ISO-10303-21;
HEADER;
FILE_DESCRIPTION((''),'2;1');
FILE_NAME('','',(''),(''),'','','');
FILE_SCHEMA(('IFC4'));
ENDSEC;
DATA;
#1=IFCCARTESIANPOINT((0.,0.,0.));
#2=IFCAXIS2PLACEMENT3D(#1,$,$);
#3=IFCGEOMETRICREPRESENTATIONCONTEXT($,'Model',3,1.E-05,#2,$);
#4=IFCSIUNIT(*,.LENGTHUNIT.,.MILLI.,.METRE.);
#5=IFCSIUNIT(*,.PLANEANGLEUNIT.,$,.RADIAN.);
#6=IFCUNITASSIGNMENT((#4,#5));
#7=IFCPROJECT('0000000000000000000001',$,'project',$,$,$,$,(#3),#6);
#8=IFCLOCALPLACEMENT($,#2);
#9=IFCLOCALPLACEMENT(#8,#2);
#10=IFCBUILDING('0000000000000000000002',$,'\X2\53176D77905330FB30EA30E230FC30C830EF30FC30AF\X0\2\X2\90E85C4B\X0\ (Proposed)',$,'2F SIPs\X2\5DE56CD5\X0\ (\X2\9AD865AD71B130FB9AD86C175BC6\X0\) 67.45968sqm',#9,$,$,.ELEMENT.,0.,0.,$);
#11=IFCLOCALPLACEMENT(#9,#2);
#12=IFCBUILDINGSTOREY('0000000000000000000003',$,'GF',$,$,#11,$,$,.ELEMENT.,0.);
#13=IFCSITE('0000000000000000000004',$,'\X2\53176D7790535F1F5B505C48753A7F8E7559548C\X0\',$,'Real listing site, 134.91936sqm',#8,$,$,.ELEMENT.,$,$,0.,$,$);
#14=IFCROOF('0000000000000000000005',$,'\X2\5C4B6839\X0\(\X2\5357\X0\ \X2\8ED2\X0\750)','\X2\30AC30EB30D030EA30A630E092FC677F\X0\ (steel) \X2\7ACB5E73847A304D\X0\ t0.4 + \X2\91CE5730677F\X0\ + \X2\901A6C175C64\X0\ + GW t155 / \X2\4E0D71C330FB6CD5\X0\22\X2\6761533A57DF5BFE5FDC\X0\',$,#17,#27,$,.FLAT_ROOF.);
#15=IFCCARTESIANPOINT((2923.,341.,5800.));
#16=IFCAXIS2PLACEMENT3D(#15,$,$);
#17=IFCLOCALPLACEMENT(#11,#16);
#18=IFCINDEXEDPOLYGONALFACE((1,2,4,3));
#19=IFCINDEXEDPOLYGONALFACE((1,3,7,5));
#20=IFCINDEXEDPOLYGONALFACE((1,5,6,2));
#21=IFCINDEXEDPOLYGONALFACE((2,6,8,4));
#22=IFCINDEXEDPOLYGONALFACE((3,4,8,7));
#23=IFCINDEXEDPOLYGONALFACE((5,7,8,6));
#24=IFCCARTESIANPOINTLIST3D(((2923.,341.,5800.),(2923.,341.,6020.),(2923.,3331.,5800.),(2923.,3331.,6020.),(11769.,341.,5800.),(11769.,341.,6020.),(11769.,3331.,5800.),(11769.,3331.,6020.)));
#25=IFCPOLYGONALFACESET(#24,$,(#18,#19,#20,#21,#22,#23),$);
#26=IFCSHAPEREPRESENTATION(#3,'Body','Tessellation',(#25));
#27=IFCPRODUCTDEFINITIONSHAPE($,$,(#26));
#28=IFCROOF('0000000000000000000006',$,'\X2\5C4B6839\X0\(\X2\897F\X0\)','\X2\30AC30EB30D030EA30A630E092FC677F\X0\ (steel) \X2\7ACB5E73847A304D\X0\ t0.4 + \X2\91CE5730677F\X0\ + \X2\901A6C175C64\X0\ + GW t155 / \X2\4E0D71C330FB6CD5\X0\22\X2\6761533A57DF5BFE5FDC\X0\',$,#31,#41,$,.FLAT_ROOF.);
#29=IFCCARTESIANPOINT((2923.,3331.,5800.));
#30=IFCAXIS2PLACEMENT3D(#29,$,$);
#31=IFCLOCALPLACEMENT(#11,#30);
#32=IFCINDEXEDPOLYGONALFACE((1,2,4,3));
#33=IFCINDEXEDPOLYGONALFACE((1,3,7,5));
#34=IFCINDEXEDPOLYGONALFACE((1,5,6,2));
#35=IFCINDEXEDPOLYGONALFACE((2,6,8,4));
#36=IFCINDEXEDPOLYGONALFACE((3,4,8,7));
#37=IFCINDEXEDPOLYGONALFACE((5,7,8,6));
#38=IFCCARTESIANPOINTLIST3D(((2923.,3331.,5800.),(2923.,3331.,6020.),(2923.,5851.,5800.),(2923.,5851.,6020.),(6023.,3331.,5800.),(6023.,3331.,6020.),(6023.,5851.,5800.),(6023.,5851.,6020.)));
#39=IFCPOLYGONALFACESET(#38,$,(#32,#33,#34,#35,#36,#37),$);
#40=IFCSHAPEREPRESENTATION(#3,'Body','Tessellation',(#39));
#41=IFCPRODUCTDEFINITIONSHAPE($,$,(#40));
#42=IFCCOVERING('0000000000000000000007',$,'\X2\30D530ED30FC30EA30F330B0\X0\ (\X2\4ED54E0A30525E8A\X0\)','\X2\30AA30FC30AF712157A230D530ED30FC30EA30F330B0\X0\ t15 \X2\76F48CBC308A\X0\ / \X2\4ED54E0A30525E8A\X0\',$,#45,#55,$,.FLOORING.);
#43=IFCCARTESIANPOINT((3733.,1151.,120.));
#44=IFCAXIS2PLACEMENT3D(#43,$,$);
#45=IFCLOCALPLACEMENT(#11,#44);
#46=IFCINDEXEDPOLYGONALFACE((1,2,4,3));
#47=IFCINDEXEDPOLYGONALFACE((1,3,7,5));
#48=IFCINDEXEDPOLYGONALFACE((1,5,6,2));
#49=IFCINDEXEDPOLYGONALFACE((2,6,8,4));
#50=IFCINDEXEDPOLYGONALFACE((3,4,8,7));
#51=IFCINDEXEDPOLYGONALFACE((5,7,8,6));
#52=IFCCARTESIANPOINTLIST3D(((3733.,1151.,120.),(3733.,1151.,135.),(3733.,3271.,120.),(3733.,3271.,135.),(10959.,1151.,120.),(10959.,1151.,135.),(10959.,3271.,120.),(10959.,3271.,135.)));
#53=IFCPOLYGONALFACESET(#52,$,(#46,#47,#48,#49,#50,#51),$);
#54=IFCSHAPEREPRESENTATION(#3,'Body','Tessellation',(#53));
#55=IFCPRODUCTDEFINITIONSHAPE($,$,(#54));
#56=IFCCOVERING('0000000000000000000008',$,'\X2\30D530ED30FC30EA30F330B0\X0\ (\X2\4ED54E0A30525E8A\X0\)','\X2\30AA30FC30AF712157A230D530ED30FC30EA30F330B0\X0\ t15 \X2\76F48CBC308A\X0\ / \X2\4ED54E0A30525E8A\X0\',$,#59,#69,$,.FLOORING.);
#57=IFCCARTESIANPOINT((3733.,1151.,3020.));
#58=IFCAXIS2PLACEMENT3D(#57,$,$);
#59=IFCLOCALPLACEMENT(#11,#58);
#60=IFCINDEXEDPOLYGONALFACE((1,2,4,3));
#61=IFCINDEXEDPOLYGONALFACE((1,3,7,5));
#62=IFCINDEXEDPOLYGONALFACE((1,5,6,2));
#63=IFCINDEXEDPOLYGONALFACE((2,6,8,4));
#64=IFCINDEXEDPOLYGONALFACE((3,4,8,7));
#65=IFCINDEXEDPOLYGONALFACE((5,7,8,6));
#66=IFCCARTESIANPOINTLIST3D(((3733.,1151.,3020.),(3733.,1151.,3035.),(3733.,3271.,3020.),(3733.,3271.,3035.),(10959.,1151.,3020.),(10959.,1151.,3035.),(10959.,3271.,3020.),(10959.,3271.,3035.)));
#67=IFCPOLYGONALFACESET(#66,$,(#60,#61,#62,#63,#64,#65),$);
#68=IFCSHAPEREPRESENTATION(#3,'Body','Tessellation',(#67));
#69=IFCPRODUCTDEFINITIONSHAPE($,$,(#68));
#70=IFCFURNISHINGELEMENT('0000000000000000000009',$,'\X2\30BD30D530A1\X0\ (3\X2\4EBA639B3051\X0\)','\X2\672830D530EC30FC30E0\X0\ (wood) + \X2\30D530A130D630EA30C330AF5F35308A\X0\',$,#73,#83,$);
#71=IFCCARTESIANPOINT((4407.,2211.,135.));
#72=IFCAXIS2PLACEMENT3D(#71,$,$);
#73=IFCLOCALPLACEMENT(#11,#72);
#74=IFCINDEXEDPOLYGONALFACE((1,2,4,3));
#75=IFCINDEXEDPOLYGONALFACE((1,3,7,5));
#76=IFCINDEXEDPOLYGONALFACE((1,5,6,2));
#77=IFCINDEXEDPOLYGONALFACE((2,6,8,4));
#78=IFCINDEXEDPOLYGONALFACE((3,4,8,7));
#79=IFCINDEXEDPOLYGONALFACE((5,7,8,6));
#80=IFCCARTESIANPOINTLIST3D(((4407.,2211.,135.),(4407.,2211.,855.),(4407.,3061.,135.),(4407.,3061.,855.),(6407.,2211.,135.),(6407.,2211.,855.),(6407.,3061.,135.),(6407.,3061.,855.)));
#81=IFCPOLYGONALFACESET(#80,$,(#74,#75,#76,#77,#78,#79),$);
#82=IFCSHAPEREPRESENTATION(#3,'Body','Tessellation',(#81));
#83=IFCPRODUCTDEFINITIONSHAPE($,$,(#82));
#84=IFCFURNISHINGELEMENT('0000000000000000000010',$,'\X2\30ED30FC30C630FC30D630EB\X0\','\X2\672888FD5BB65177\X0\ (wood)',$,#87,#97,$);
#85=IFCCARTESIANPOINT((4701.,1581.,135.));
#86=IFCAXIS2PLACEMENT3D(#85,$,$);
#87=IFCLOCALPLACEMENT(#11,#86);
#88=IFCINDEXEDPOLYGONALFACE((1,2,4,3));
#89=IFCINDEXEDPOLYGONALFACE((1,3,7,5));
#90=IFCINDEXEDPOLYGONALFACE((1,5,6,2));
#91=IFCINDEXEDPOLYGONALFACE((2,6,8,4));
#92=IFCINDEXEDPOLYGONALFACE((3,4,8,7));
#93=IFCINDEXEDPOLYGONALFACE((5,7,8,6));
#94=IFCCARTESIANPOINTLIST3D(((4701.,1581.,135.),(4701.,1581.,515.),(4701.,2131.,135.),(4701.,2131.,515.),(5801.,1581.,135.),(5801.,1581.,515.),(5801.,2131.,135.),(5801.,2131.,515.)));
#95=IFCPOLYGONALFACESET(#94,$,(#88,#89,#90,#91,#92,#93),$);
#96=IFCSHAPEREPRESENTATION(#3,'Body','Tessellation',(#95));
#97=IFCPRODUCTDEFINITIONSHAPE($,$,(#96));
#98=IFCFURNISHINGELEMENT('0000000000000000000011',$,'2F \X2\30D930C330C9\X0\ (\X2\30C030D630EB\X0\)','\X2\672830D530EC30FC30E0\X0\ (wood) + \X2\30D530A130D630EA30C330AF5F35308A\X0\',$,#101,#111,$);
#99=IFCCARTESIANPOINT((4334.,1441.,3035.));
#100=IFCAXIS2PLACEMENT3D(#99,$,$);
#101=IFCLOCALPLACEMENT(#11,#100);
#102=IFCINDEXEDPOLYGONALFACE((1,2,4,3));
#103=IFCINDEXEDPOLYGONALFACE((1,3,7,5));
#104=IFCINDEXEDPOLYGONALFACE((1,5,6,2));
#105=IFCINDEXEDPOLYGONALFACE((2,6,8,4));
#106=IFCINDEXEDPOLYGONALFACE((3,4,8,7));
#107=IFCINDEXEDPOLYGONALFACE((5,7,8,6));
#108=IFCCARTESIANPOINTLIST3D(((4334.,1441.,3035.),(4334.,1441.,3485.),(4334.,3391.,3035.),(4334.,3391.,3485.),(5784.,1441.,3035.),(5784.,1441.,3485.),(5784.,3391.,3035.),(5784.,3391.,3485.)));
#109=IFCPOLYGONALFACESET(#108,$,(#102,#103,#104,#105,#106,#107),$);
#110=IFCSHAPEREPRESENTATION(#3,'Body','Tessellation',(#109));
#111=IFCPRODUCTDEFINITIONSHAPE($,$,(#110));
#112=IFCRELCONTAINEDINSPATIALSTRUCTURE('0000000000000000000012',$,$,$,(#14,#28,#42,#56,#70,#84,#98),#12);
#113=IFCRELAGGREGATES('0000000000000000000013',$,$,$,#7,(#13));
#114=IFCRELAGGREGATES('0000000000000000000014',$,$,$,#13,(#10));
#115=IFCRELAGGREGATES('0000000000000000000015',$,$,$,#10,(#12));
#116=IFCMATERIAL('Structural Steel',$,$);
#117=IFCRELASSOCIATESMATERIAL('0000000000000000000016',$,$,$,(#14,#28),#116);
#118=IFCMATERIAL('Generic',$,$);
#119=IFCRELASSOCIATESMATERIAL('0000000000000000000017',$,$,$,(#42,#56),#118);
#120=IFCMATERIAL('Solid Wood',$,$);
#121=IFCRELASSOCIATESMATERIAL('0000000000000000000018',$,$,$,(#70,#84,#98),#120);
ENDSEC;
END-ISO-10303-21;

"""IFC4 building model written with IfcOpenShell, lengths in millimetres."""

from ifc_helpers import new_model, si_unit, frame, frame_2d, origin, place, context, project, spatial, rectangle, extrude, material, element, save


model = new_model("IFC4")

# Units and contexts
model_context = context("Model", 3, precision=1e-05, world=origin())
ifc_project = project(units=[si_unit("LENGTHUNIT", "METRE", prefix="MILLI"), si_unit("PLANEANGLEUNIT", "RADIAN")], contexts=[model_context])

# Site, building, storey
site_placement = place(None, origin())
site = spatial("IfcSite", under=ifc_project, at=site_placement, Name="北海道弟子屈町美留和", ObjectType="Real listing site, 134.91936sqm", CompositionType="ELEMENT", RefElevation=0.0)
building_placement = place(site_placement, origin())
building = spatial("IfcBuilding", under=site, at=building_placement, Name="北海道・リモートワーク2部屋 (Proposed)", ObjectType="2F SIPs工法 (高断熱・高気密) 67.45968sqm", CompositionType="ELEMENT", ElevationOfRefHeight=0.0, ElevationOfTerrain=0.0)
storey_placement = place(building_placement, origin())
storey = spatial("IfcBuildingStorey", under=building, at=storey_placement, Name="GF", CompositionType="ELEMENT", Elevation=0.0)

# Shared definitions
ifc_material_1 = material(Name="Solid Wood")

# Roofs
ifc_material_2 = material(Name="Structural Steel")
roof_1_placement = place(storey_placement, frame((2923.0, 341.0, 5800.0)))
element("IfcRoof", 1, at=roof_1_placement, inside=storey, material=ifc_material_2, Name="屋根(南 軒750)", Description="ガルバリウム鋼板 (steel) 立平葺き t0.4 + 野地板 + 通気層 + GW t155 / 不燃・法22条区域対応", PredefinedType="FLAT_ROOF", context=model_context, shape_type="SweptSolid", body=[
    extrude(rectangle(XDim=8846.0, YDim=2990.0, at=frame_2d((4423.0, 1495.0))), frame((2923.0, 341.0, 5800.0)), (0.0, 0.0, 1.0), 220.0),
])
roof_2_placement = place(storey_placement, frame((2923.0, 3331.0, 5800.0)))
element("IfcRoof", 2, at=roof_2_placement, inside=storey, material=ifc_material_2, Name="屋根(西)", Description="ガルバリウム鋼板 (steel) 立平葺き t0.4 + 野地板 + 通気層 + GW t155 / 不燃・法22条区域対応", PredefinedType="FLAT_ROOF", context=model_context, shape_type="SweptSolid", body=[
    extrude(rectangle(XDim=3100.0, YDim=2520.0, at=frame_2d((1550.0, 1260.0))), frame((2923.0, 3331.0, 5800.0)), (0.0, 0.0, 1.0), 220.0),
])

# Coverings
ifc_material_3 = material(Name="Generic")
covering_1_placement = place(storey_placement, frame((3733.0, 1151.0, 120.0)))
element("IfcCovering", 3, at=covering_1_placement, inside=storey, material=ifc_material_3, Name="フローリング (仕上げ床)", Description="オーク無垢フローリング t15 直貼り / 仕上げ床", PredefinedType="FLOORING", context=model_context, shape_type="SweptSolid", body=[
    extrude(rectangle(XDim=7226.0, YDim=2120.0, at=frame_2d((3613.0, 1060.0))), frame((3733.0, 1151.0, 120.0)), (0.0, 0.0, 1.0), 15.0),
])
covering_2_placement = place(storey_placement, frame((3733.0, 1151.0, 3020.0)))
element("IfcCovering", 4, at=covering_2_placement, inside=storey, material=ifc_material_3, Name="フローリング (仕上げ床)", Description="オーク無垢フローリング t15 直貼り / 仕上げ床", PredefinedType="FLOORING", context=model_context, shape_type="SweptSolid", body=[
    extrude(rectangle(XDim=7226.0, YDim=2120.0, at=frame_2d((3613.0, 1060.0))), frame((3733.0, 1151.0, 3020.0)), (0.0, 0.0, 1.0), 15.0),
])

# Furnishing elements
furnishing_1_placement = place(storey_placement, frame((4407.0, 2211.0, 135.0)))
element("IfcFurnishingElement", 5, at=furnishing_1_placement, inside=storey, material=ifc_material_1, Name="ソファ (3人掛け)", Description="木フレーム (wood) + ファブリック張り", context=model_context, shape_type="SweptSolid", body=[
    extrude(rectangle(XDim=2000.0, YDim=850.0, at=frame_2d((1000.0, 425.0))), frame((4407.0, 2211.0, 135.0)), (0.0, 0.0, 1.0), 720.0),
])
furnishing_2_placement = place(storey_placement, frame((4701.0, 1581.0, 135.0)))
element("IfcFurnishingElement", 6, at=furnishing_2_placement, inside=storey, material=ifc_material_1, Name="ローテーブル", Description="木製家具 (wood)", context=model_context, shape_type="SweptSolid", body=[
    extrude(rectangle(XDim=1100.0, YDim=550.0, at=frame_2d((550.0, 275.0))), frame((4701.0, 1581.0, 135.0)), (0.0, 0.0, 1.0), 380.0),
])
furnishing_3_placement = place(storey_placement, frame((4334.0, 1441.0, 3035.0)))
element("IfcFurnishingElement", 7, at=furnishing_3_placement, inside=storey, material=ifc_material_1, Name="2F ベッド (ダブル)", Description="木フレーム (wood) + ファブリック張り", context=model_context, shape_type="SweptSolid", body=[
    extrude(rectangle(XDim=1450.0, YDim=1950.0, at=frame_2d((725.0, 975.0))), frame((4334.0, 1441.0, 3035.0)), (0.0, 0.0, 1.0), 450.0),
])

save(model, "model.ifc")
